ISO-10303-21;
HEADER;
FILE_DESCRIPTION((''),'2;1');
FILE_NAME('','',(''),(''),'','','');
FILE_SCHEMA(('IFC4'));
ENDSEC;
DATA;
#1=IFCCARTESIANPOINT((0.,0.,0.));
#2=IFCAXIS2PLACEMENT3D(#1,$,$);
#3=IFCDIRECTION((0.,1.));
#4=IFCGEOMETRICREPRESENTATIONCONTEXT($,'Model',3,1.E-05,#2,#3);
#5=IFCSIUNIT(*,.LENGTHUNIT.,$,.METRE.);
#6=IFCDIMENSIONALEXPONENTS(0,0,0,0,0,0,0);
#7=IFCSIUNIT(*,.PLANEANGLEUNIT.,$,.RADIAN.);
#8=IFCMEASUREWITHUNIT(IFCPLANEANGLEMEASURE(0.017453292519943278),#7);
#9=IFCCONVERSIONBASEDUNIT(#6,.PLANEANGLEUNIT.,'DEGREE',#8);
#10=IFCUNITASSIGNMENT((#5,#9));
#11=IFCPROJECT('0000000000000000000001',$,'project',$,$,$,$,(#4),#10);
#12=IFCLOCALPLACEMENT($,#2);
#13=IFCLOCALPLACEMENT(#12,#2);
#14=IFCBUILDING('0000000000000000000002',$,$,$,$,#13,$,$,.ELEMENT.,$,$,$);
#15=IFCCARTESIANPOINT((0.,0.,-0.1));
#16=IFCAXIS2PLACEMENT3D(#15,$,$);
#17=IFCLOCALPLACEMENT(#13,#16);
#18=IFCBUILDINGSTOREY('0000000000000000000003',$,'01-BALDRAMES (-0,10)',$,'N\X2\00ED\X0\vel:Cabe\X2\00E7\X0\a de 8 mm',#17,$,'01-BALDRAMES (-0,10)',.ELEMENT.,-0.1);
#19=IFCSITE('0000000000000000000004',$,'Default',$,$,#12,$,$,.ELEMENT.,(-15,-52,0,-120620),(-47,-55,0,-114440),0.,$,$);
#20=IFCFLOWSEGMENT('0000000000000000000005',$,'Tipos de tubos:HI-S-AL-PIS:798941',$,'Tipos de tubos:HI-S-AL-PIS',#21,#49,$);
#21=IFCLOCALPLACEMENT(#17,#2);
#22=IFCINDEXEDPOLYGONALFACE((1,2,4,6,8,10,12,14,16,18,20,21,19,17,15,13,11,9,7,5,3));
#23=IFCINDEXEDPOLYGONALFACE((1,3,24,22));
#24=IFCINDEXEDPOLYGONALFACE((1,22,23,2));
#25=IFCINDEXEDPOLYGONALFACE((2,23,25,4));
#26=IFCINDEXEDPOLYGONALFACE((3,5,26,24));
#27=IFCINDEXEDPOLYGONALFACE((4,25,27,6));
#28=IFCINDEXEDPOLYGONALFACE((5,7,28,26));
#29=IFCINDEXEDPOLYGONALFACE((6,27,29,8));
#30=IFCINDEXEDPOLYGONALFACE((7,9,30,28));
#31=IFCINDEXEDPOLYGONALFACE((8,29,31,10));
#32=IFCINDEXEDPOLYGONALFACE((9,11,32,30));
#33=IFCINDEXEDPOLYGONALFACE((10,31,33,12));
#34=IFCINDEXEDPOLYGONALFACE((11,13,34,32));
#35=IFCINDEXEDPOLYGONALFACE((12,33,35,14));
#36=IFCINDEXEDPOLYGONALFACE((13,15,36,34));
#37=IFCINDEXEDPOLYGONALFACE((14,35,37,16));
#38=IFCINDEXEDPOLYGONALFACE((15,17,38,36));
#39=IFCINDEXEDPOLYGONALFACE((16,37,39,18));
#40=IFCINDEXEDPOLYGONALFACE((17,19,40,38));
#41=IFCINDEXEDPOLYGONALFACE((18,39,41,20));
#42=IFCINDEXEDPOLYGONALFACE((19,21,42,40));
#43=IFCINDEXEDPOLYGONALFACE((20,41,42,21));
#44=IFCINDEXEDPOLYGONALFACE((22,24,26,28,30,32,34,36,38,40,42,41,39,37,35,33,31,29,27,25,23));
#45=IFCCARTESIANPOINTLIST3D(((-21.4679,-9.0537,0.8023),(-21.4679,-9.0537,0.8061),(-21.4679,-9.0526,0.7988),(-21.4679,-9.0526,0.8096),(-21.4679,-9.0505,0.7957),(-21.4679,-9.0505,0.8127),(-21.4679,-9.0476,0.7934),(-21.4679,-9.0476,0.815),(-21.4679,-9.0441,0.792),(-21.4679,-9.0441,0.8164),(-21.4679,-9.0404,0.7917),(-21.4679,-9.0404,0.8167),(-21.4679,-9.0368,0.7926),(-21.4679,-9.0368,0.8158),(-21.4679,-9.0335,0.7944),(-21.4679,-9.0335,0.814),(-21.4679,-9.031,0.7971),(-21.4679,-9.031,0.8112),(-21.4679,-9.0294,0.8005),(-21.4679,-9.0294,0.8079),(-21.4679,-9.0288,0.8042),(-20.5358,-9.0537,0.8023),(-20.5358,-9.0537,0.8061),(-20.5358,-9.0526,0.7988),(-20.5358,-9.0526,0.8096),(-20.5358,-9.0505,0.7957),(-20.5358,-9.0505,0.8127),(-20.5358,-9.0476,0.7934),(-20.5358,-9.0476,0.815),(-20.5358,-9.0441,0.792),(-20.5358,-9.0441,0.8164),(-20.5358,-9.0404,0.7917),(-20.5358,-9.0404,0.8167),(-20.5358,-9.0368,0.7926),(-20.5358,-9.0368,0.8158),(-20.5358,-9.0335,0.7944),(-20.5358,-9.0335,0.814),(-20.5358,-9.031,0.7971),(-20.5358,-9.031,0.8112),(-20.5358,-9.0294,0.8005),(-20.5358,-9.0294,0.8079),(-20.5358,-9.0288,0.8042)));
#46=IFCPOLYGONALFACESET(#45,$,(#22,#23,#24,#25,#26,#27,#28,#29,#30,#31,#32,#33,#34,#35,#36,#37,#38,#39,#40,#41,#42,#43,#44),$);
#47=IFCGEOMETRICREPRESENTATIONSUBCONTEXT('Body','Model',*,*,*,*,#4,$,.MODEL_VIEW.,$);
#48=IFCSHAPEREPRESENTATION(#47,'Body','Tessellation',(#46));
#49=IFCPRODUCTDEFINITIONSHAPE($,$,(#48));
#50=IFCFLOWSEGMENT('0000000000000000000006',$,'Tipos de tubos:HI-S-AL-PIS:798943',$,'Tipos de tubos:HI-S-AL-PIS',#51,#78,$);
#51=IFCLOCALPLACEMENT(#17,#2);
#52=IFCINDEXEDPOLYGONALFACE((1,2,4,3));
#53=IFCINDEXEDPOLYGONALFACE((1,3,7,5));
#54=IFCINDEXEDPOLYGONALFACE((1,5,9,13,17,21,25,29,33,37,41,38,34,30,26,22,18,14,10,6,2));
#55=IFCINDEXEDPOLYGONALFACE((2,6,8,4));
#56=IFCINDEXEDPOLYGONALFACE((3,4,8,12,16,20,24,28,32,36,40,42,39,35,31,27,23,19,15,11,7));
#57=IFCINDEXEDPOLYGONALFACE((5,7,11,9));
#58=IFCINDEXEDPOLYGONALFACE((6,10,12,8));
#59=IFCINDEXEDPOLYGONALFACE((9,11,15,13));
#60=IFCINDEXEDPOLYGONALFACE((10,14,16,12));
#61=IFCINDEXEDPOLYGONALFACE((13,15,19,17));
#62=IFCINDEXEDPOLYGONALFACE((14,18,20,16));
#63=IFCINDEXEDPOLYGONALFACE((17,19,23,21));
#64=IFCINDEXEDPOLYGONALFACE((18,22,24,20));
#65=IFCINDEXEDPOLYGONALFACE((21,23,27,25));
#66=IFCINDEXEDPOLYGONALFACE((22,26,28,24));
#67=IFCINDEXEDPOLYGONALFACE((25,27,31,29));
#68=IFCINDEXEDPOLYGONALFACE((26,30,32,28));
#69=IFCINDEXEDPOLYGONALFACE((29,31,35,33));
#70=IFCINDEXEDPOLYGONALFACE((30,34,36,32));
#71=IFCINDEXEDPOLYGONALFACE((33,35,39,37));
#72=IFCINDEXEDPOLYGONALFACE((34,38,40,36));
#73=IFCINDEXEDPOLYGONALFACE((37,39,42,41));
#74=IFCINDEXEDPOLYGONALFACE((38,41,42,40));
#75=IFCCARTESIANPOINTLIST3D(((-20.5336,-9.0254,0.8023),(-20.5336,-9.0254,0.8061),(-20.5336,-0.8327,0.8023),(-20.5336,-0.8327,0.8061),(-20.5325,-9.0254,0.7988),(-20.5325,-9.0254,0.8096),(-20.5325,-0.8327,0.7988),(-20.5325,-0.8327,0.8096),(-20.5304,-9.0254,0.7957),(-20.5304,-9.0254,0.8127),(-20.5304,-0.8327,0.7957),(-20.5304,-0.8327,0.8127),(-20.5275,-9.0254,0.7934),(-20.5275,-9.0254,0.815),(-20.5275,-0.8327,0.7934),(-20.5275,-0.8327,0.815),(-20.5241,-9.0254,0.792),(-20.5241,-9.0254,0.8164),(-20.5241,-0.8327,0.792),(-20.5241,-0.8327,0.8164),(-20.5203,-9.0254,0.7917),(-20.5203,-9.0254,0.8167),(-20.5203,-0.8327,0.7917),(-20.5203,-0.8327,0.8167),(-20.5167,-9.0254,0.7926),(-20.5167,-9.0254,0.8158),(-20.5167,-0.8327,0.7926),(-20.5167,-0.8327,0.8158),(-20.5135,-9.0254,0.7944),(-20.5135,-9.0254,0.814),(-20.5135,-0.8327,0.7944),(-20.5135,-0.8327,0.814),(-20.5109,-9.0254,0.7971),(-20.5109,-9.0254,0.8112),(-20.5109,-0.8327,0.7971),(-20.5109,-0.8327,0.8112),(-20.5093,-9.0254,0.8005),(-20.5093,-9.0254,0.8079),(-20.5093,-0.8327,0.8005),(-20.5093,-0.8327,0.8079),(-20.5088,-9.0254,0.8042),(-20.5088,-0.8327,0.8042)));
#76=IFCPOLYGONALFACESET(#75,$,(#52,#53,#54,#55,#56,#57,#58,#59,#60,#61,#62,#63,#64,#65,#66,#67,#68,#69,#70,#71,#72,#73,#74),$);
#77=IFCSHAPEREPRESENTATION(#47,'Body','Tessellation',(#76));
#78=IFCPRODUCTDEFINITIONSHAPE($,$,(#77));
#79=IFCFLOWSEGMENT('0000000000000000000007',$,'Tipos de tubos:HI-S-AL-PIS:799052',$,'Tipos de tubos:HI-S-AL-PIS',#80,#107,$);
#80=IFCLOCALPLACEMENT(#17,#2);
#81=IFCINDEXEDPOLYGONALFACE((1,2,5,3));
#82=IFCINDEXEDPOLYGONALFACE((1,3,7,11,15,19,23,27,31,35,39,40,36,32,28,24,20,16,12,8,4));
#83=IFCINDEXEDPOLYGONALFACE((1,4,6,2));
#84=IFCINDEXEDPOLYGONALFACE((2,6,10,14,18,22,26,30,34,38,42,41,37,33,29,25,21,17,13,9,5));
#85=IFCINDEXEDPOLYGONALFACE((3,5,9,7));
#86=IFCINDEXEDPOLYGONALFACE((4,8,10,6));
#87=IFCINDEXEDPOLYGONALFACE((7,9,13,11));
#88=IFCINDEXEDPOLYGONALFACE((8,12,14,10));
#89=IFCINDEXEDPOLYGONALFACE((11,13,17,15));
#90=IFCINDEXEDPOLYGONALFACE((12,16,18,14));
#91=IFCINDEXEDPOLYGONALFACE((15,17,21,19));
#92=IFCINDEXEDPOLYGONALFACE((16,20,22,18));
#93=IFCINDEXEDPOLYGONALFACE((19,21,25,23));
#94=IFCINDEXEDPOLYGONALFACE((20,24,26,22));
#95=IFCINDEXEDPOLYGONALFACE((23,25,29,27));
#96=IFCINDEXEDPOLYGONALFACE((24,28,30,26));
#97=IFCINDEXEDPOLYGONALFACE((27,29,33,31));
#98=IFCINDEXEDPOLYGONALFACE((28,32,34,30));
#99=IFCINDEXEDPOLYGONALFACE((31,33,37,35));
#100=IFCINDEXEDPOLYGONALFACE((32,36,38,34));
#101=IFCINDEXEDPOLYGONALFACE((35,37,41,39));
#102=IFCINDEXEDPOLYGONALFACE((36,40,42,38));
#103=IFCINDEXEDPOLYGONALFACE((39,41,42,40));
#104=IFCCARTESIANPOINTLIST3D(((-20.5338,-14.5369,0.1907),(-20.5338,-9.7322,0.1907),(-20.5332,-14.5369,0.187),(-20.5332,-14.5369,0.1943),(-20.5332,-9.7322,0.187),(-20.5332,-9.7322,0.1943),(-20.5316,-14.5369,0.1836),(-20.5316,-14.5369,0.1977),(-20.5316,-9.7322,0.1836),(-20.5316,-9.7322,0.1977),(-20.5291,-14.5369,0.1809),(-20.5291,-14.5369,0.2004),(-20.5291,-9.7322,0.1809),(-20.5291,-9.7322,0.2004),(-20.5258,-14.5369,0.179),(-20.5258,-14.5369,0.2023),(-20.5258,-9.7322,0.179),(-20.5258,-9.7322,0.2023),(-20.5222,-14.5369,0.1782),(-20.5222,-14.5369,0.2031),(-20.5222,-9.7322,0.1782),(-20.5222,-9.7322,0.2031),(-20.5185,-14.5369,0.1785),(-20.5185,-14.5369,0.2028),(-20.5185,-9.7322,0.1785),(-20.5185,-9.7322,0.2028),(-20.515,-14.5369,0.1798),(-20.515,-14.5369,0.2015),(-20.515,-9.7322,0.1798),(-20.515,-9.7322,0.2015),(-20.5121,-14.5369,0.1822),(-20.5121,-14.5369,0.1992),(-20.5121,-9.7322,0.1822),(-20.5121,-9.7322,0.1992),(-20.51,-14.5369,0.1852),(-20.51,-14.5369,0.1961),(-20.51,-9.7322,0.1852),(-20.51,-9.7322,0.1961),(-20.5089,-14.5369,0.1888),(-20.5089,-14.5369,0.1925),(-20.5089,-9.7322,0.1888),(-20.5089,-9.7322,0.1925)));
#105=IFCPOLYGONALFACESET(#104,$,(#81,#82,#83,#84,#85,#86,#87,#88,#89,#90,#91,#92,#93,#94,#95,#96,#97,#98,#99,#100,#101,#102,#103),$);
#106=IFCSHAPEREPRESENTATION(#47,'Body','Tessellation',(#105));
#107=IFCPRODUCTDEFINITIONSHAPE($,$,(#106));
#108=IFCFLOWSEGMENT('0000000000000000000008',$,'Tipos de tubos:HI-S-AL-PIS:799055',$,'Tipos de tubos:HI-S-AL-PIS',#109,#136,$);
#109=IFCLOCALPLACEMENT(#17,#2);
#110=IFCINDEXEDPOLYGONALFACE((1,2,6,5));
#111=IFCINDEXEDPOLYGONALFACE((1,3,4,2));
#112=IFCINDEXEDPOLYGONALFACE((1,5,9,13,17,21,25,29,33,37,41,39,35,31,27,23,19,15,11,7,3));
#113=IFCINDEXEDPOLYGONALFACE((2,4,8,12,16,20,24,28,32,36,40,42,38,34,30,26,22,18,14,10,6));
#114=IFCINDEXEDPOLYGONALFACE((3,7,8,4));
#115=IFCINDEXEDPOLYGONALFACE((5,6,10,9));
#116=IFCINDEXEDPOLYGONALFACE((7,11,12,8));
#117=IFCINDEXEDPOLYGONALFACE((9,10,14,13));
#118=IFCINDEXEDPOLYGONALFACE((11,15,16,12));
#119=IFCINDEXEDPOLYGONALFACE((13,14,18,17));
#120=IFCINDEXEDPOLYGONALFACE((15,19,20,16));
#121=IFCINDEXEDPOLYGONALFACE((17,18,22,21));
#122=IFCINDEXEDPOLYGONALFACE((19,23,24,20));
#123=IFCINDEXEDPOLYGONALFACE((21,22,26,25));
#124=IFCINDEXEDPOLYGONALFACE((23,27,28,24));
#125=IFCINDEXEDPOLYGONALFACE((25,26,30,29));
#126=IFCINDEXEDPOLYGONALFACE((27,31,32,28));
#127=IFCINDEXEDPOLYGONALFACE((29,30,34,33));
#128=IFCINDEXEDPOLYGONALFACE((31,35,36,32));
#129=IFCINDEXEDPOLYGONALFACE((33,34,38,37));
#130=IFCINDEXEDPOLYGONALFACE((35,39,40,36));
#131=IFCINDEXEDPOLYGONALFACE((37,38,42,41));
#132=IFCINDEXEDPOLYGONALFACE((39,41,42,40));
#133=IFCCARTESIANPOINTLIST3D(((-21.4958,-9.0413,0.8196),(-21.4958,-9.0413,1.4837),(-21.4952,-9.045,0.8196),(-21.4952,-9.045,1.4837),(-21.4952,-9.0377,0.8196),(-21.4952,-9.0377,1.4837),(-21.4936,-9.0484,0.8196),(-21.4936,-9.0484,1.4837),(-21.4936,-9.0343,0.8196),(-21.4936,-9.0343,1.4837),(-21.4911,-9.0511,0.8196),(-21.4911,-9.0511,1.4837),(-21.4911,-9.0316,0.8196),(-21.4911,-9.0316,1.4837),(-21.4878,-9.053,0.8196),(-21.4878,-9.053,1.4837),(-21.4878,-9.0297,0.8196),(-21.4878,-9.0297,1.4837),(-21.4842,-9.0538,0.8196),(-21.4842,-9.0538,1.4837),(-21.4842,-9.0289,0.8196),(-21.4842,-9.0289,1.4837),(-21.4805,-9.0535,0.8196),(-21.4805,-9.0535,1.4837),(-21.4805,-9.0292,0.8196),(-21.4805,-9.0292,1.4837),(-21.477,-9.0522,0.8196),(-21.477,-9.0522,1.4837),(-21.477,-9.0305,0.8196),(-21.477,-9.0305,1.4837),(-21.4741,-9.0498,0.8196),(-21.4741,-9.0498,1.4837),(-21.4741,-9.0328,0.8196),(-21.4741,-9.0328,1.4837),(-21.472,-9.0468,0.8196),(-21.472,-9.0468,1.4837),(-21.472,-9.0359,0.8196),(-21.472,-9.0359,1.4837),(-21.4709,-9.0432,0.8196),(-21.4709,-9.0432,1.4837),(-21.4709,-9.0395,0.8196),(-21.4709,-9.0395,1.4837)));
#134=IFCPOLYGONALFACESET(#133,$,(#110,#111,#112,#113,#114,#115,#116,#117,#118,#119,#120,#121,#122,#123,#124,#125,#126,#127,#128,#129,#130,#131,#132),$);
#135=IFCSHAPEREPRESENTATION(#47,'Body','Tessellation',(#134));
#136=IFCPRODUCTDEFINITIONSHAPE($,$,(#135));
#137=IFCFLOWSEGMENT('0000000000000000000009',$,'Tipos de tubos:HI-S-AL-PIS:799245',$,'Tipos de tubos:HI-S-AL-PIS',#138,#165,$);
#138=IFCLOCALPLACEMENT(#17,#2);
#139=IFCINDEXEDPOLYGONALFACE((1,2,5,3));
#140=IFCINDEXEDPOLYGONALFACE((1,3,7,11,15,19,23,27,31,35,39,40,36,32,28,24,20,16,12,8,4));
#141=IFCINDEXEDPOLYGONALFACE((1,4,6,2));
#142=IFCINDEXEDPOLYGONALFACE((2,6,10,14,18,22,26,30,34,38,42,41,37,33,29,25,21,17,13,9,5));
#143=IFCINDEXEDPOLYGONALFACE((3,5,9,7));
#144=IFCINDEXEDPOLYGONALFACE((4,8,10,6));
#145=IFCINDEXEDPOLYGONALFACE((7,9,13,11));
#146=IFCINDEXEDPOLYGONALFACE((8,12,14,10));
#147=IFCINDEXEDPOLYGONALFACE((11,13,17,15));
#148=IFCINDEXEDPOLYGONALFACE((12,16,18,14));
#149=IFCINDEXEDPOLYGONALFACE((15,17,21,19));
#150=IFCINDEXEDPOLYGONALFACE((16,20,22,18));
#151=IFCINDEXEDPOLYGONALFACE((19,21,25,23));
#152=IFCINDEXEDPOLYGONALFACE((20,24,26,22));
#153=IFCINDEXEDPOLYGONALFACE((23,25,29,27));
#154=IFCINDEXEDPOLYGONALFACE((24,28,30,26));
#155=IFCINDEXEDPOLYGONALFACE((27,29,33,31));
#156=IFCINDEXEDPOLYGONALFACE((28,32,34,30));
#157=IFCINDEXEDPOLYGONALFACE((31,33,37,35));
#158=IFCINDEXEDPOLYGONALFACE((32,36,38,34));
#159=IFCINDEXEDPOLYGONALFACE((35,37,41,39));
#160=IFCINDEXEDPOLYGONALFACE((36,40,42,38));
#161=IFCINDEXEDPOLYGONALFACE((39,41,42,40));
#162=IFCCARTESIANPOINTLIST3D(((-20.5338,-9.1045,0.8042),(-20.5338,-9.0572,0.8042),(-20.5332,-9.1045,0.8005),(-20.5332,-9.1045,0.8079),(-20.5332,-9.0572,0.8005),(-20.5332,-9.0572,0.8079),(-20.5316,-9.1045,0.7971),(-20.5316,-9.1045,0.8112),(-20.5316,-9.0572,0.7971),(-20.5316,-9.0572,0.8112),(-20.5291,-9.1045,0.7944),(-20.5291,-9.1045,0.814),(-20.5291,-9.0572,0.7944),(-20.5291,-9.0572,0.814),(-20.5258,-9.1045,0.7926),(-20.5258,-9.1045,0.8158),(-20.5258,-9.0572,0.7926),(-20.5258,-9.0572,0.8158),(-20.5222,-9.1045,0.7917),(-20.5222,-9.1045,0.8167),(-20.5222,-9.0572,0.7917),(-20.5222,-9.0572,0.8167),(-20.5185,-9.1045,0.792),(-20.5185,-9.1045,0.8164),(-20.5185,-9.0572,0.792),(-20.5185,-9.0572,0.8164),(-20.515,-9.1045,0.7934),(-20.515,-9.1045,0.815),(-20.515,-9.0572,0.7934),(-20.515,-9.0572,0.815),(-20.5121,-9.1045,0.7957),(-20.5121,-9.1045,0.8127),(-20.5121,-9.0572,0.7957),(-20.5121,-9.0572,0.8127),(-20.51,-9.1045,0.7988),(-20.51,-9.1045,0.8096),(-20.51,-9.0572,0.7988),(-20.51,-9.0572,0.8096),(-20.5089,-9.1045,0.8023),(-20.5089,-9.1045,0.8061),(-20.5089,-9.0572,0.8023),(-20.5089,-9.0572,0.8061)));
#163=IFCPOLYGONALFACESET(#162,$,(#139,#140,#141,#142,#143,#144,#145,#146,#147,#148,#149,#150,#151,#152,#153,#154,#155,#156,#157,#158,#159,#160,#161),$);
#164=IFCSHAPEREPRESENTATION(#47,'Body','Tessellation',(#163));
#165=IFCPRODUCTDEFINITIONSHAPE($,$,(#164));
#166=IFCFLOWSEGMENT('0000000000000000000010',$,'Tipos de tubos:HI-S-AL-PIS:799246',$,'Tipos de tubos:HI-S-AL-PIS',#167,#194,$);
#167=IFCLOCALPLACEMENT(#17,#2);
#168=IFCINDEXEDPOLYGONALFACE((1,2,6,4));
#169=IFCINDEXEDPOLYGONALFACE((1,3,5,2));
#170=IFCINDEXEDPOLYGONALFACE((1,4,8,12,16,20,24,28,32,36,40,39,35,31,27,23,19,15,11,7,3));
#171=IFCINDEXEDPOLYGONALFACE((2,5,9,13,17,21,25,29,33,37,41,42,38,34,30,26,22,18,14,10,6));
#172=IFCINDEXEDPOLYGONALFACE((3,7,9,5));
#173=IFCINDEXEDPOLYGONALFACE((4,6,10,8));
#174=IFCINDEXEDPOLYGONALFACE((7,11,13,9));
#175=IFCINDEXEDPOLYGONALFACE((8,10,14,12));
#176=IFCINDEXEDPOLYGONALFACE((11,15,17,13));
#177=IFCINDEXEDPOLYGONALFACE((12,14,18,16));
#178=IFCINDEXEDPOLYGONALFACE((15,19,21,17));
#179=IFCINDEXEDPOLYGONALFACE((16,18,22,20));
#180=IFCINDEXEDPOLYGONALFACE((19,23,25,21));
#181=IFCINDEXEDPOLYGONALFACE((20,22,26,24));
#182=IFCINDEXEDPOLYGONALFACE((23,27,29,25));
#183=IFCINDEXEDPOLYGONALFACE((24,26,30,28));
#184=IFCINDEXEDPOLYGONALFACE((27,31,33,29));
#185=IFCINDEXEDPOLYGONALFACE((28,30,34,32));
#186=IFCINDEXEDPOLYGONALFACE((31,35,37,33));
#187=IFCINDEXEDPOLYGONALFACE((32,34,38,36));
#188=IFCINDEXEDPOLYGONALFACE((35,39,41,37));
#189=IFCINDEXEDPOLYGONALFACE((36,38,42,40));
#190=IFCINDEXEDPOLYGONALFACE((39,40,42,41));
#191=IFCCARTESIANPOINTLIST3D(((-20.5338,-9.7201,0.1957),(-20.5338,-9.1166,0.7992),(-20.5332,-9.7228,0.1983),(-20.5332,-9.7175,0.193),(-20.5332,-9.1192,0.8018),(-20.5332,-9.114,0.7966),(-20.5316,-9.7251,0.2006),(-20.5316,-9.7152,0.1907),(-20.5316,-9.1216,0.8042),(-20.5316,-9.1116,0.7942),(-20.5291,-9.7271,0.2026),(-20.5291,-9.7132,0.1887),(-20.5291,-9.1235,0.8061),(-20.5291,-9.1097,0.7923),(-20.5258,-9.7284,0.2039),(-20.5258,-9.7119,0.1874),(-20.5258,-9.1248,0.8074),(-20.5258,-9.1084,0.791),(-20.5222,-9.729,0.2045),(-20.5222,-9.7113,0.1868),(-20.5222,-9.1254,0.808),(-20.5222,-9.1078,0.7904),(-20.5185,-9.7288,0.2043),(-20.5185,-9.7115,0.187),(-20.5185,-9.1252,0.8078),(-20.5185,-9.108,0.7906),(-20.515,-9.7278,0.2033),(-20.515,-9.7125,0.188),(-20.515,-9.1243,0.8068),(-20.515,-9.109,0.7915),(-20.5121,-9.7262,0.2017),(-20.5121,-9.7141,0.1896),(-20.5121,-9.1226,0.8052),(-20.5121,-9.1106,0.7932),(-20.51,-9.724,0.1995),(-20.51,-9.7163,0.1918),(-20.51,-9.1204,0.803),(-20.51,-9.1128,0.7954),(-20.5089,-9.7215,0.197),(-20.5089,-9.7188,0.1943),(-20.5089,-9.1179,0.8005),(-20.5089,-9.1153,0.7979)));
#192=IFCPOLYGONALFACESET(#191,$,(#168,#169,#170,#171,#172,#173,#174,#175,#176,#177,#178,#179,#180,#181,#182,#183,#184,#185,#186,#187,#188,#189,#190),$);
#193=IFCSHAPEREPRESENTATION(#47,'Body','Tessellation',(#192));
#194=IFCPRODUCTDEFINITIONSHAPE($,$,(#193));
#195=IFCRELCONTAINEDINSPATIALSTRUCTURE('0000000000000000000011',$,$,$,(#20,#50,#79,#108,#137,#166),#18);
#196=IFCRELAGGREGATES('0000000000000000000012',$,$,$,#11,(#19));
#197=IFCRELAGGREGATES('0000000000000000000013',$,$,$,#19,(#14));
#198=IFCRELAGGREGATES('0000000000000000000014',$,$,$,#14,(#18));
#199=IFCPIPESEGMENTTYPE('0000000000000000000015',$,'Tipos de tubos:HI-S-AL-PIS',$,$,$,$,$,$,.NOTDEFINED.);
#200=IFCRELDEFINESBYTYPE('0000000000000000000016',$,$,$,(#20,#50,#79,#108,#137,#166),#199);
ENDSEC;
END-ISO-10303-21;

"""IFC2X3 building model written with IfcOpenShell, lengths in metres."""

from ifc_helpers import new_model, entity, si_unit, converted_unit, direction, frame, frame_2d, origin, origin_2d_with_axis, place, context, subcontext, project, spatial, circle, extrude, type_object, element, save


model = new_model("IFC2X3")

# Units and contexts
model_context = context("Model", 3, precision=1e-05, world=origin(), true_north=direction((0.0, 1.0)))
body_context = subcontext(model_context, "Body", "Model", "MODEL_VIEW")
ifc_project = project(units=[si_unit("LENGTHUNIT", "METRE"), converted_unit("PLANEANGLEUNIT", "DEGREE", entity("IfcPlaneAngleMeasure", 0.017453292519943278), si_unit("PLANEANGLEUNIT", "RADIAN"), dimensions=[0, 0, 0, 0, 0, 0, 0])], contexts=[model_context])

# Site, building, storey
site_placement = place(None, origin())
site = spatial("IfcSite", under=ifc_project, at=site_placement, Name="Default", CompositionType="ELEMENT", RefLatitude=(-15, -52, 0, -120620), RefLongitude=(-47, -55, 0, -114440), RefElevation=0.0)
building_placement = place(site_placement, origin())
building = spatial("IfcBuilding", under=site, at=building_placement, CompositionType="ELEMENT")
storey_placement = place(building_placement, frame((0.0, 0.0, -0.1)))
storey = spatial("IfcBuildingStorey", under=building, at=storey_placement, Name="01-BALDRAMES (-0,10)", ObjectType="Nível:Cabeça de 8 mm", LongName="01-BALDRAMES (-0,10)", CompositionType="ELEMENT", Elevation=-0.1)

# Flow segments
pipe_segment_type_1 = type_object("IfcPipeSegmentType", Name="Tipos de tubos:HI-S-AL-PIS", PredefinedType="NOTDEFINED")
flow_segment_1_placement = place(storey_placement, origin())
element("IfcFlowSegment", 1, at=flow_segment_1_placement, inside=storey, type_object=pipe_segment_type_1, Name="Tipos de tubos:HI-S-AL-PIS:798941", ObjectType="Tipos de tubos:HI-S-AL-PIS", context=body_context, shape_type="SweptSolid", body=[
    extrude(circle(Radius=0.0125, at=origin_2d_with_axis()), frame((-21.4679, -9.0413, 0.8042), z_axis=(1.0, 0.0, 0.0), x_axis=(0.0, 1.0, 0.0)), (0.0, 0.0, 1.0), 0.9321),
])
flow_segment_2_placement = place(storey_placement, origin())
element("IfcFlowSegment", 2, at=flow_segment_2_placement, inside=storey, type_object=pipe_segment_type_1, Name="Tipos de tubos:HI-S-AL-PIS:798943", ObjectType="Tipos de tubos:HI-S-AL-PIS", context=body_context, shape_type="SweptSolid", body=[
    extrude(circle(Radius=0.0125, at=origin_2d_with_axis()), frame((-20.5213, -9.0254, 0.8042), z_axis=(0.0, 1.0, 0.0), x_axis=(1.0, 0.0, 0.0)), (0.0, 0.0, 1.0), 8.1927),
])
flow_segment_3_placement = place(storey_placement, origin())
element("IfcFlowSegment", 3, at=flow_segment_3_placement, inside=storey, type_object=pipe_segment_type_1, Name="Tipos de tubos:HI-S-AL-PIS:799052", ObjectType="Tipos de tubos:HI-S-AL-PIS", context=body_context, shape_type="SweptSolid", body=[
    extrude(circle(Radius=0.0125, at=frame_2d((0.0, 0.0), x_axis=(1.0, 0.0))), frame((-20.5213, -14.5369, 0.1907), z_axis=(0.0, 1.0, 0.0), x_axis=(-1.0, 0.0, 0.0)), (0.0, 0.0, 1.0), 4.8047),
])
flow_segment_4_placement = place(storey_placement, origin())
element("IfcFlowSegment", 4, at=flow_segment_4_placement, inside=storey, type_object=pipe_segment_type_1, Name="Tipos de tubos:HI-S-AL-PIS:799055", ObjectType="Tipos de tubos:HI-S-AL-PIS", context=body_context, shape_type="SweptSolid", body=[
    extrude(circle(Radius=0.0125, at=origin_2d_with_axis()), frame((-21.4833, -9.0413, 0.8196), z_axis=(0.0, 0.0, 1.0), x_axis=(-1.0, 0.0, 0.0)), (0.0, 0.0, 1.0), 0.6641),
])
flow_segment_5_placement = place(storey_placement, origin())
element("IfcFlowSegment", 5, at=flow_segment_5_placement, inside=storey, type_object=pipe_segment_type_1, Name="Tipos de tubos:HI-S-AL-PIS:799245", ObjectType="Tipos de tubos:HI-S-AL-PIS", context=body_context, shape_type="SweptSolid", body=[
    extrude(circle(Radius=0.0125, at=origin_2d_with_axis()), frame((-20.5213, -9.1045, 0.8042), z_axis=(0.0, 1.0, 0.0), x_axis=(-1.0, 0.0, 0.0)), (0.0, 0.0, 1.0), 0.0473),
])
flow_segment_6_placement = place(storey_placement, origin())
element("IfcFlowSegment", 6, at=flow_segment_6_placement, inside=storey, type_object=pipe_segment_type_1, Name="Tipos de tubos:HI-S-AL-PIS:799246", ObjectType="Tipos de tubos:HI-S-AL-PIS", context=body_context, shape_type="SweptSolid", body=[
    extrude(circle(Radius=0.0125, at=frame_2d((0.0, 0.0), x_axis=(1.0, 0.0))), frame((-20.5213, -9.7201, 0.1957), z_axis=(0.0, 0.707107, 0.707107), x_axis=(-1.0, 0.0, 0.0)), (0.0, 0.0, 1.0), 0.8535),
])

save(model, "model.ifc")
